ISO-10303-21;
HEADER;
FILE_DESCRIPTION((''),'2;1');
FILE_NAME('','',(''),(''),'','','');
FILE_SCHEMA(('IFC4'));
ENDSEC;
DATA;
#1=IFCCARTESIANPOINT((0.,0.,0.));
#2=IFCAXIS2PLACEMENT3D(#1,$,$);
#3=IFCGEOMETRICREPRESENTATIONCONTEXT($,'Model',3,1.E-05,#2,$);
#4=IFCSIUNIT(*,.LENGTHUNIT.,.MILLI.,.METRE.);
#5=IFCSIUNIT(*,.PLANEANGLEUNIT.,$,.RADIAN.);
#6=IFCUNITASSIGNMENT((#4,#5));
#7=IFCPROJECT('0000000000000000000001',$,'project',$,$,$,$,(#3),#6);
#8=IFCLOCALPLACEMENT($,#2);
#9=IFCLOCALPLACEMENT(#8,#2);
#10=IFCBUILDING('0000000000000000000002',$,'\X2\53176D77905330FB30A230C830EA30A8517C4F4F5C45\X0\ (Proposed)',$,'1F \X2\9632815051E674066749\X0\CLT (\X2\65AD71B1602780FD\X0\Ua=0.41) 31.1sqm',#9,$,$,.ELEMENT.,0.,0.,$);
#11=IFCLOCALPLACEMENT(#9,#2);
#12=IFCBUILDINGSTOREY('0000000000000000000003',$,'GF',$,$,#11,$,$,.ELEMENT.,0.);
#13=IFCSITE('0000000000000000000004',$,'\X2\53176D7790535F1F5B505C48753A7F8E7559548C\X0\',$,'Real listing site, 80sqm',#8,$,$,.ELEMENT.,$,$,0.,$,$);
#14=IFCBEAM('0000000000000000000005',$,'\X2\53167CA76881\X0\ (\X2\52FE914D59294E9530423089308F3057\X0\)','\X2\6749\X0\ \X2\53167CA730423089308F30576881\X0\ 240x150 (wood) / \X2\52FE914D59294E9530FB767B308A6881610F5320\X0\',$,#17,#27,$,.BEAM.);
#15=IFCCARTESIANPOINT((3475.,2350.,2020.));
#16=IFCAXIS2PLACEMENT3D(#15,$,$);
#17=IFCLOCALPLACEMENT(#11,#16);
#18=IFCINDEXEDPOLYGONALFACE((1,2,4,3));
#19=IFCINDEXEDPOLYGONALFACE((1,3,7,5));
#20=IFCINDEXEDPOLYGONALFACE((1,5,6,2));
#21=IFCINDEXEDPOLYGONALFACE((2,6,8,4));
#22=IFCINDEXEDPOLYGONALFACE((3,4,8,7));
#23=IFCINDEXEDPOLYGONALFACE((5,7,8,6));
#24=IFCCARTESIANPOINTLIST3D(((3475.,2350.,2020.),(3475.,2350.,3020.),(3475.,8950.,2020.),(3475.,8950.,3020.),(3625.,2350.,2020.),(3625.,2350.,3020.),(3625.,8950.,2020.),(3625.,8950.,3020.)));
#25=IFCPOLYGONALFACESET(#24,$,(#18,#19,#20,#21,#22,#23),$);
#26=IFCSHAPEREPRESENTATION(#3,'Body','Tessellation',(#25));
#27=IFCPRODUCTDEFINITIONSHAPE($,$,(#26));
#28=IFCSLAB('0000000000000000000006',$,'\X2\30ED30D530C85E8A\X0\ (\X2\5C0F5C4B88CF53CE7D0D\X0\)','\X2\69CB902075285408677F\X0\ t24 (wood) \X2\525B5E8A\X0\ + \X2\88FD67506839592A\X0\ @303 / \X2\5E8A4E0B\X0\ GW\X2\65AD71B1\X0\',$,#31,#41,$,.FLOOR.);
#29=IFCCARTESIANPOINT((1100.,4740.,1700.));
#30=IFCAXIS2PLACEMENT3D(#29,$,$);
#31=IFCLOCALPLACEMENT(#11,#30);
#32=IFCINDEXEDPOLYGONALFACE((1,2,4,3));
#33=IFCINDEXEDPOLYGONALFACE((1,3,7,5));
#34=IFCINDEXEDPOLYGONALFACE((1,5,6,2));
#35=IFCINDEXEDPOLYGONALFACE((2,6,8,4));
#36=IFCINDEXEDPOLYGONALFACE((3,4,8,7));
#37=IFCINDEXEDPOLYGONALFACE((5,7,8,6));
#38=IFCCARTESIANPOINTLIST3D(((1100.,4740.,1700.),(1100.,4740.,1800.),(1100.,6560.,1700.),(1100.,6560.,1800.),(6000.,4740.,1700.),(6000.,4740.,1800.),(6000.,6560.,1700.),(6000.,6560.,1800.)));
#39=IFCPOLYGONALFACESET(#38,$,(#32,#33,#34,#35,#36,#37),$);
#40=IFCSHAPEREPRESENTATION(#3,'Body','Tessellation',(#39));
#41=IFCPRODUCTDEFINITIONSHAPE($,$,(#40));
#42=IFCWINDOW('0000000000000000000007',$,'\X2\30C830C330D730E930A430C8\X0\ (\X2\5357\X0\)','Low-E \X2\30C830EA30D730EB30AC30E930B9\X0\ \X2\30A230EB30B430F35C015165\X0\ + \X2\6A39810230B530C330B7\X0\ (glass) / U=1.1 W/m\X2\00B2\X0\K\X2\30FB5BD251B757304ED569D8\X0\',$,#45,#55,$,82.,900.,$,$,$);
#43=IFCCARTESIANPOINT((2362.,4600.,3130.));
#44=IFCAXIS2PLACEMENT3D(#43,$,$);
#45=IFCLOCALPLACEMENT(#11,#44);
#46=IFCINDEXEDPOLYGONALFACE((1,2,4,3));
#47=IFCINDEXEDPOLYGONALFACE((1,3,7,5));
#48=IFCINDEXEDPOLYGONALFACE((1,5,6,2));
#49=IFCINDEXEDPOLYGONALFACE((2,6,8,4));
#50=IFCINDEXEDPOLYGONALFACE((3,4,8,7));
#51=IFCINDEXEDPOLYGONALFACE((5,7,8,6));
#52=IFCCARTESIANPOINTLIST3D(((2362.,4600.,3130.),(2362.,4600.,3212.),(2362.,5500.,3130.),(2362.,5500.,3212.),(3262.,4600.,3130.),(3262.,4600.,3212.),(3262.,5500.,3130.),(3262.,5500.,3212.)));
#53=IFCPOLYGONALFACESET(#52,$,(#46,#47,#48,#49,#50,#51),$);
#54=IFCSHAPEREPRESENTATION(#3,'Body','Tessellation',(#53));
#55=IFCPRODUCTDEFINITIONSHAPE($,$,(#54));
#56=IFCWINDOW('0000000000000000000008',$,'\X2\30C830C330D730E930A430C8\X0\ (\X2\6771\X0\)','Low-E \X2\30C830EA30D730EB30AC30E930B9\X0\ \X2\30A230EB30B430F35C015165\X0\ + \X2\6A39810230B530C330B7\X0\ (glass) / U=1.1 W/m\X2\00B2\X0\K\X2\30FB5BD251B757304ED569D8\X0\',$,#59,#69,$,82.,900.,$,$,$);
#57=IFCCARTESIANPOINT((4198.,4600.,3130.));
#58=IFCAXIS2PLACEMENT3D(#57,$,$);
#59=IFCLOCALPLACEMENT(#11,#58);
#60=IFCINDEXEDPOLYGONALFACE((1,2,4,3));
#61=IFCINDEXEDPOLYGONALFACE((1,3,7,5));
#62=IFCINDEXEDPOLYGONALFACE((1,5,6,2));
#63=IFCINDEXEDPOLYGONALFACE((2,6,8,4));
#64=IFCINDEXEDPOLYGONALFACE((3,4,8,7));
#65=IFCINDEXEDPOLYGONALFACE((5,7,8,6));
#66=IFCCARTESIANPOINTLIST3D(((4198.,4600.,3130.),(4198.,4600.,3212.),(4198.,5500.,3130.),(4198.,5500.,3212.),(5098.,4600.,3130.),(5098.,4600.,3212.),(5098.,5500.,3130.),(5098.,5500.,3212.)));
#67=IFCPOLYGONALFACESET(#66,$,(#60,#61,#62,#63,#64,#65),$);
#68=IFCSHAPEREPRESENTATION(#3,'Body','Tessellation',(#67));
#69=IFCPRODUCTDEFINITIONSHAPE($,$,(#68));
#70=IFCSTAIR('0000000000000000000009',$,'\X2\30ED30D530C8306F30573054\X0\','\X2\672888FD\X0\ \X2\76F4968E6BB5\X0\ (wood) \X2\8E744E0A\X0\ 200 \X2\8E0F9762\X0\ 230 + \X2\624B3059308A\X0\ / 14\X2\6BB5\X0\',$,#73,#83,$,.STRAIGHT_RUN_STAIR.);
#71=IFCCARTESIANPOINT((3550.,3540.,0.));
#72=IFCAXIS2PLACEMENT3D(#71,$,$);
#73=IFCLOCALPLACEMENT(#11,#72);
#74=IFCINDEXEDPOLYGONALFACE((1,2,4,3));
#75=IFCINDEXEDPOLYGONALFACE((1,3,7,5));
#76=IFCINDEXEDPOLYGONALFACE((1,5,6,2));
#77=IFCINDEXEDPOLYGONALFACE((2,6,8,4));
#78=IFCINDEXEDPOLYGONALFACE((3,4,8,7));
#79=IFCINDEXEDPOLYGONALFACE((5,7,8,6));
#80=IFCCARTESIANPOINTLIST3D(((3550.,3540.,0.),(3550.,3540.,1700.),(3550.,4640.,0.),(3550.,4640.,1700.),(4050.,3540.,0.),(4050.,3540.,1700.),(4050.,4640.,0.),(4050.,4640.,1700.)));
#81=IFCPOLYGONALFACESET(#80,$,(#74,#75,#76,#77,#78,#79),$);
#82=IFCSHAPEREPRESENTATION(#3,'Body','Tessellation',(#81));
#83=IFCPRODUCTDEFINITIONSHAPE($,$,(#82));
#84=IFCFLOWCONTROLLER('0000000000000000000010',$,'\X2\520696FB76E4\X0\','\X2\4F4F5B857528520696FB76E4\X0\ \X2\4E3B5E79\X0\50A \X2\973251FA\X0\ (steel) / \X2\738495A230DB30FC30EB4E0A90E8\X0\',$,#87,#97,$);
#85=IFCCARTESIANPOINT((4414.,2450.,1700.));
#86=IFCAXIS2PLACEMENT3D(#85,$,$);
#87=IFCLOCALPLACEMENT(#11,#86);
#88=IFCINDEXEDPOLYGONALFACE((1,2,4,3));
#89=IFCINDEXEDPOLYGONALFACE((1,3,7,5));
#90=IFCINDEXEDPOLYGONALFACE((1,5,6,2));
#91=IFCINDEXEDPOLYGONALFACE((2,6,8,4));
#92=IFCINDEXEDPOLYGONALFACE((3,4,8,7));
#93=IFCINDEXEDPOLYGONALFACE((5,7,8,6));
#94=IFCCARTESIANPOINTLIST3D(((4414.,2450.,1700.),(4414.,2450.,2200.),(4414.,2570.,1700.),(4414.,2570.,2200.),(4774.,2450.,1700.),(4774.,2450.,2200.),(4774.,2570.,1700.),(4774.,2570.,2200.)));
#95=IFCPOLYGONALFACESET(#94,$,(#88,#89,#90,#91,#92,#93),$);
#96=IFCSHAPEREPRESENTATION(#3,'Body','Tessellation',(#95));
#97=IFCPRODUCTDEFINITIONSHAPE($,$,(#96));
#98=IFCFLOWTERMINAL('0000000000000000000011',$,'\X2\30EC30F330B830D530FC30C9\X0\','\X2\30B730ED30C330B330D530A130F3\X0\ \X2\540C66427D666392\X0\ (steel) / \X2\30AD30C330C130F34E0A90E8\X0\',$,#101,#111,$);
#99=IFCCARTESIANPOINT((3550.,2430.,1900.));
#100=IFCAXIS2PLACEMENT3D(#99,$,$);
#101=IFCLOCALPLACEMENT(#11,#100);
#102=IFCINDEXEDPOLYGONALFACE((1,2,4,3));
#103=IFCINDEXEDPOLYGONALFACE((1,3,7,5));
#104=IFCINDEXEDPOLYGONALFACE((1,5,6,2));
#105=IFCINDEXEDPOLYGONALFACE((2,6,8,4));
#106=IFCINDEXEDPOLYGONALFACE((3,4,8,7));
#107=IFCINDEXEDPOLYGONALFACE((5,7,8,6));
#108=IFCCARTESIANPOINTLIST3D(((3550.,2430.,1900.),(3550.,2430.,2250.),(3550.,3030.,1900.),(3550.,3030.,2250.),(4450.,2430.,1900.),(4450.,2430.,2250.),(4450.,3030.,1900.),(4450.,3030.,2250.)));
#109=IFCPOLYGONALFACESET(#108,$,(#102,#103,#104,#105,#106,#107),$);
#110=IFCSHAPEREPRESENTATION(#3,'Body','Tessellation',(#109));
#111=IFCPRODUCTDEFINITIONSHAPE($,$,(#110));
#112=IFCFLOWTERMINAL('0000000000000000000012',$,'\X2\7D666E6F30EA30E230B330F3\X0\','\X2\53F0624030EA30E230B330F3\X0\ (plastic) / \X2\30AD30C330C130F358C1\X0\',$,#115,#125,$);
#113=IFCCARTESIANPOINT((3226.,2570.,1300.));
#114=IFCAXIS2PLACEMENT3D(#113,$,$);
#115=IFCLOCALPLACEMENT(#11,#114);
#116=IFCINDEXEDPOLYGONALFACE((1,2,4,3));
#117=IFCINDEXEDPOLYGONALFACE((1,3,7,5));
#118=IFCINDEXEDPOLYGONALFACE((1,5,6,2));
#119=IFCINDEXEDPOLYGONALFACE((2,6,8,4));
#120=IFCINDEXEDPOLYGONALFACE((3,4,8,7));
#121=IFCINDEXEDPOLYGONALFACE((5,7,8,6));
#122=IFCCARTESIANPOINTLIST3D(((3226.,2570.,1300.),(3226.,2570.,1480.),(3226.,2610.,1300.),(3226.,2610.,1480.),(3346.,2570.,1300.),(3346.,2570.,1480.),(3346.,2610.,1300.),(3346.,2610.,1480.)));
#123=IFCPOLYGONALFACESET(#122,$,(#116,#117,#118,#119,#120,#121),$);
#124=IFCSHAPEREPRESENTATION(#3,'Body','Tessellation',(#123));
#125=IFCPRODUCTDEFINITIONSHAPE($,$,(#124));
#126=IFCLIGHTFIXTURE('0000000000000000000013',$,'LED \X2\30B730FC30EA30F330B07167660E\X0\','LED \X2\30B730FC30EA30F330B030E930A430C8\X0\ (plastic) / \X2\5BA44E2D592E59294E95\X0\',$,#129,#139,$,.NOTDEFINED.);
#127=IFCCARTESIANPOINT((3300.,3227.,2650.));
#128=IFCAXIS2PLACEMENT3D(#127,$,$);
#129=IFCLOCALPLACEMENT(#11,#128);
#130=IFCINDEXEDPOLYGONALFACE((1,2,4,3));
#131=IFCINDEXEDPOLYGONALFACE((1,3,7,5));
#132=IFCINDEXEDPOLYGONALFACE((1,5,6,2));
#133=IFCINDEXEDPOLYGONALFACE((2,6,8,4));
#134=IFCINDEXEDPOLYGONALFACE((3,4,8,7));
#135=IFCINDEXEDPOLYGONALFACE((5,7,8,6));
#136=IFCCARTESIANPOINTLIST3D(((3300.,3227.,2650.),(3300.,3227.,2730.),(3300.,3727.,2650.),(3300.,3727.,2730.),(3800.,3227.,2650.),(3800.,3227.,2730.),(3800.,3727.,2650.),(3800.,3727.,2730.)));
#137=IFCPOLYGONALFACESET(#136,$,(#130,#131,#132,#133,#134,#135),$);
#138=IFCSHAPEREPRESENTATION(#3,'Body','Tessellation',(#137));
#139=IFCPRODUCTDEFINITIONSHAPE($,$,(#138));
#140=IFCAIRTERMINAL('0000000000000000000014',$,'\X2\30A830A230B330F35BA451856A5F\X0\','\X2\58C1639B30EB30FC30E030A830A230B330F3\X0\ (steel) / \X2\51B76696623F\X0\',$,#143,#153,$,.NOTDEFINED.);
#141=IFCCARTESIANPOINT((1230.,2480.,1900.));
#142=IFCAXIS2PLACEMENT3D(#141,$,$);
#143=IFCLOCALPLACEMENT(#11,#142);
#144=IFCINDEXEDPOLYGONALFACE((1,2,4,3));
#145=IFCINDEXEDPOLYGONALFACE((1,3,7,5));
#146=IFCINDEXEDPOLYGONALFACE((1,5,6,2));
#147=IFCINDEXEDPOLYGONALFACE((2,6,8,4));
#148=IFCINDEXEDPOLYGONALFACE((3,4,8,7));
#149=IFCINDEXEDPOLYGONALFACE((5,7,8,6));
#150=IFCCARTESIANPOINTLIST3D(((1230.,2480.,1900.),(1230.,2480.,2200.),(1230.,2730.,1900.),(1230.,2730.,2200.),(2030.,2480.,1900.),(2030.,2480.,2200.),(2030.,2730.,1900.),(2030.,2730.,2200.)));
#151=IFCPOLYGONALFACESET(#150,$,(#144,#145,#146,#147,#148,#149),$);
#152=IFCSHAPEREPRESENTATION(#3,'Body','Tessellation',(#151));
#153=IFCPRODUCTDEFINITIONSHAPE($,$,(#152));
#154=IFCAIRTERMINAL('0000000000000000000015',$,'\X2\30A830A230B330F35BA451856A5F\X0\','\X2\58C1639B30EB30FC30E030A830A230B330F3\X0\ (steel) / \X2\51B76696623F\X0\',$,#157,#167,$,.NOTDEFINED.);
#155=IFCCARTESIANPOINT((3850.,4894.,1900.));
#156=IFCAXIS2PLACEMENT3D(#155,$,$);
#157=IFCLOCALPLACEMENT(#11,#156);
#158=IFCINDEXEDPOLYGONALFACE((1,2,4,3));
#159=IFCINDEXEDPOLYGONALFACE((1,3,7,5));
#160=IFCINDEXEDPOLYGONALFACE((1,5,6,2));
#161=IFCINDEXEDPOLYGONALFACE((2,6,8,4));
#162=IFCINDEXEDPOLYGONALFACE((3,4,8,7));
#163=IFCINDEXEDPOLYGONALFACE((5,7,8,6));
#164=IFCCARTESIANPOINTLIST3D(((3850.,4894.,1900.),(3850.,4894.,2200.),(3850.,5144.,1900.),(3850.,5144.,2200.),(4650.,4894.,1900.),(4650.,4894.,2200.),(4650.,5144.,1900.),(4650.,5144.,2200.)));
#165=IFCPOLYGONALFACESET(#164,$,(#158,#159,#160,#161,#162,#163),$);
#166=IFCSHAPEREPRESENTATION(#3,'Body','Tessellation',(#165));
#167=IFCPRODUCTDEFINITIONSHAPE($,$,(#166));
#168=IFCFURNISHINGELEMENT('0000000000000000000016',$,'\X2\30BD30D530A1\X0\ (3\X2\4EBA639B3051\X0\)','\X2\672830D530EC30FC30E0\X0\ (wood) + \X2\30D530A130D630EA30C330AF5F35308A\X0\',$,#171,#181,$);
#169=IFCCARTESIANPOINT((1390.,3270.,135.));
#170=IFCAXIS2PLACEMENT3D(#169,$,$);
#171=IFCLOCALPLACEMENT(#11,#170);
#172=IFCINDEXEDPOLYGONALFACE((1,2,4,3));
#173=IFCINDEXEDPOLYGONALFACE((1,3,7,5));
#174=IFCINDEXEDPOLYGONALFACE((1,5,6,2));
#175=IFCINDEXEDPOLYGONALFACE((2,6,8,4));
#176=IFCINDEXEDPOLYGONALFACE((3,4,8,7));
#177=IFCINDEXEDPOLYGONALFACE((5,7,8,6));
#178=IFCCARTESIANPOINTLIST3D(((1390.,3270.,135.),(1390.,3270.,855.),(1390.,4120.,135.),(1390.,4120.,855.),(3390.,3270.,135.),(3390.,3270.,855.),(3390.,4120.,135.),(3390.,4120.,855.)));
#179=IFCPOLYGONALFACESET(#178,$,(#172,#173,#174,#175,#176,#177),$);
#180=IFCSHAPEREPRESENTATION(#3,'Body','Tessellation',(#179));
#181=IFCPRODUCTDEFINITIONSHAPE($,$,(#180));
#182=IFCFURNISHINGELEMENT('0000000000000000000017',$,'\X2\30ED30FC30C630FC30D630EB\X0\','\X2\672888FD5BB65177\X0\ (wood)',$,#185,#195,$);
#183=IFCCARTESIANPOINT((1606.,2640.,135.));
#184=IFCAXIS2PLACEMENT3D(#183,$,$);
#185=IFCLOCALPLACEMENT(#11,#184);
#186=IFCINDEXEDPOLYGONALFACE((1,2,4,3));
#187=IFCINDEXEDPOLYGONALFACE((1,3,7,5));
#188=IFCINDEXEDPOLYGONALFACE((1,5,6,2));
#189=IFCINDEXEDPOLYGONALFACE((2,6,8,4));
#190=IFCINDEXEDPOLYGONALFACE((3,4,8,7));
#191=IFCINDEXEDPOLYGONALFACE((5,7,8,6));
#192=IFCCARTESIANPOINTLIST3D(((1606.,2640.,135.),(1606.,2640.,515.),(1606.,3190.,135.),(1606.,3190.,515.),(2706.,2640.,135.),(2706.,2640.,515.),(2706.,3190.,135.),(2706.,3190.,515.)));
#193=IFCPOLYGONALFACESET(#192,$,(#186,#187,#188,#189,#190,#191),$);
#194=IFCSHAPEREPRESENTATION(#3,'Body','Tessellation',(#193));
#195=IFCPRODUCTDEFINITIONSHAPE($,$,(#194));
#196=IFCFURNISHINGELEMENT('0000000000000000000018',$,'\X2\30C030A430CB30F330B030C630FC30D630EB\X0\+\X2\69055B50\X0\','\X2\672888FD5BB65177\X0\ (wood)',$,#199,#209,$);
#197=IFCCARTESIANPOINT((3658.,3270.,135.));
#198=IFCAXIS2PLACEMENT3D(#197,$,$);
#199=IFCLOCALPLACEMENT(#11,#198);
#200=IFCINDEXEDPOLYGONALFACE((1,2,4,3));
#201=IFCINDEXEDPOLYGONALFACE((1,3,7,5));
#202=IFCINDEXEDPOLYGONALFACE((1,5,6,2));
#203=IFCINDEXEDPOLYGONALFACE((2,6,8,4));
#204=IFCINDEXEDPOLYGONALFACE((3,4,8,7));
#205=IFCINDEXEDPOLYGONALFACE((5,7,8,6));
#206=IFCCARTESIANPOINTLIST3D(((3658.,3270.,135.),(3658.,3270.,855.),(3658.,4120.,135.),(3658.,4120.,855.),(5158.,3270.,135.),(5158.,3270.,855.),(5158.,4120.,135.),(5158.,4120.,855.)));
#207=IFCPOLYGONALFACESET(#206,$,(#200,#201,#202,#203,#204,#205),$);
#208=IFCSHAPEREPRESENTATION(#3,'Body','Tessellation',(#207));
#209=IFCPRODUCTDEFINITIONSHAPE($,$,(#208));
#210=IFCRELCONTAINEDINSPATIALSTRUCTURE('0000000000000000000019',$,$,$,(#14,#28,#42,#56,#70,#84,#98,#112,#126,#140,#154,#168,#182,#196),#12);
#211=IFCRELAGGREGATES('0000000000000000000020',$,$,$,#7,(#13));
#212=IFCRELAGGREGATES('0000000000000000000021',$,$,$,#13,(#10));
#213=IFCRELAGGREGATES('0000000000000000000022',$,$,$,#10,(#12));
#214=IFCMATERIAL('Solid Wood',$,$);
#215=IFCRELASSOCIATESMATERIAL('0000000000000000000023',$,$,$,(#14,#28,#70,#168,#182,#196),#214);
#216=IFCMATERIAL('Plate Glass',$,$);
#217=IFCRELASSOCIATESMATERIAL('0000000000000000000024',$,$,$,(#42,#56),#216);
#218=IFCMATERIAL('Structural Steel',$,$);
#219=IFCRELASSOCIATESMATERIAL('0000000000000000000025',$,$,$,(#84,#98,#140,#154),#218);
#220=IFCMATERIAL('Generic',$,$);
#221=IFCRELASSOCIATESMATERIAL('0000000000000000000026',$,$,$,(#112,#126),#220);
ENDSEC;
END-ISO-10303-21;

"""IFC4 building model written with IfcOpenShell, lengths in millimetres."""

from ifc_helpers import new_model, si_unit, frame, frame_2d, origin, place, context, project, spatial, rectangle, extrude, material, element, save


model = new_model("IFC4")

# Units and contexts
model_context = context("Model", 3, precision=1e-05, world=origin())
ifc_project = project(units=[si_unit("LENGTHUNIT", "METRE", prefix="MILLI"), si_unit("PLANEANGLEUNIT", "RADIAN")], contexts=[model_context])

# Site, building, storey
site_placement = place(None, origin())
site = spatial("IfcSite", under=ifc_project, at=site_placement, Name="北海道弟子屈町美留和", ObjectType="Real listing site, 80sqm", CompositionType="ELEMENT", RefElevation=0.0)
building_placement = place(site_placement, origin())
building = spatial("IfcBuilding", under=site, at=building_placement, Name="北海道・アトリエ兼住居 (Proposed)", ObjectType="1F 防腐処理杉CLT (断熱性能Ua=0.41) 31.1sqm", CompositionType="ELEMENT", ElevationOfRefHeight=0.0, ElevationOfTerrain=0.0)
storey_placement = place(building_placement, origin())
storey = spatial("IfcBuildingStorey", under=building, at=storey_placement, Name="GF", CompositionType="ELEMENT", Elevation=0.0)

# Shared definitions
ifc_material_1 = material(Name="Solid Wood")

# Beam
beam_placement = place(storey_placement, frame((3475.0, 2350.0, 2020.0)))
element("IfcBeam", 1, at=beam_placement, inside=storey, material=ifc_material_1, Name="化粧梁 (勾配天井あらわし)", Description="杉 化粧あらわし梁 240x150 (wood) / 勾配天井・登り梁意匠", PredefinedType="BEAM", context=model_context, shape_type="SweptSolid", body=[
    extrude(rectangle(XDim=150.0, YDim=6600.0, at=frame_2d((75.0, 3300.0))), frame((3475.0, 2350.0, 2020.0)), (0.0, 0.0, 1.0), 1000.0),
])

# Slab
slab_placement = place(storey_placement, frame((1100.0, 4740.0, 1700.0)))
element("IfcSlab", 2, at=slab_placement, inside=storey, material=ifc_material_1, Name="ロフト床 (小屋裏収納)", Description="構造用合板 t24 (wood) 剛床 + 製材根太 @303 / 床下 GW断熱", PredefinedType="FLOOR", context=model_context, shape_type="SweptSolid", body=[
    extrude(rectangle(XDim=4900.0, YDim=1820.0, at=frame_2d((2450.0, 910.0))), frame((1100.0, 4740.0, 1700.0)), (0.0, 0.0, 1.0), 100.0),
])

# Windows
ifc_material_2 = material(Name="Plate Glass")
window_1_placement = place(storey_placement, frame((2362.0, 4600.0, 3130.0)))
element("IfcWindow", 3, at=window_1_placement, inside=storey, material=ifc_material_2, Name="トップライト (南)", Description="Low-E トリプルガラス アルゴン封入 + 樹脂サッシ (glass) / U=1.1 W/m²K・寒冷地仕様", OverallHeight=82.0, OverallWidth=900.0, context=model_context, shape_type="SweptSolid", body=[
    extrude(rectangle(XDim=900.0, YDim=900.0, at=frame_2d((450.0, 450.0))), frame((2362.0, 4600.0, 3130.0)), (0.0, 0.0, 1.0), 82.0),
])
window_2_placement = place(storey_placement, frame((4198.0, 4600.0, 3130.0)))
element("IfcWindow", 4, at=window_2_placement, inside=storey, material=ifc_material_2, Name="トップライト (東)", Description="Low-E トリプルガラス アルゴン封入 + 樹脂サッシ (glass) / U=1.1 W/m²K・寒冷地仕様", OverallHeight=82.0, OverallWidth=900.0, context=model_context, shape_type="SweptSolid", body=[
    extrude(rectangle(XDim=900.0, YDim=900.0, at=frame_2d((450.0, 450.0))), frame((4198.0, 4600.0, 3130.0)), (0.0, 0.0, 1.0), 82.0),
])

# Stair
stair_placement = place(storey_placement, frame((3550.0, 3540.0, 0.0)))
element("IfcStair", 5, at=stair_placement, inside=storey, material=ifc_material_1, Name="ロフトはしご", Description="木製 直階段 (wood) 蹴上 200 踏面 230 + 手すり / 14段", PredefinedType="STRAIGHT_RUN_STAIR", context=model_context, shape_type="SweptSolid", body=[
    extrude(rectangle(XDim=500.0, YDim=1100.0, at=frame_2d((250.0, 550.0))), frame((3550.0, 3540.0, 0.0)), (0.0, 0.0, 1.0), 1700.0),
])

# Flow controller
ifc_material_3 = material(Name="Structural Steel")
flow_controller_placement = place(storey_placement, frame((4414.0, 2450.0, 1700.0)))
element("IfcFlowController", 6, at=flow_controller_placement, inside=storey, material=ifc_material_3, Name="分電盤", Description="住宅用分電盤 主幹50A 露出 (steel) / 玄関ホール上部", context=model_context, shape_type="SweptSolid", body=[
    extrude(rectangle(XDim=360.0, YDim=120.0, at=frame_2d((180.0, 60.0))), frame((4414.0, 2450.0, 1700.0)), (0.0, 0.0, 1.0), 500.0),
])

# Flow terminals
flow_terminal_1_placement = place(storey_placement, frame((3550.0, 2430.0, 1900.0)))
element("IfcFlowTerminal", 7, at=flow_terminal_1_placement, inside=storey, material=ifc_material_3, Name="レンジフード", Description="シロッコファン 同時給排 (steel) / キッチン上部", context=model_context, shape_type="SweptSolid", body=[
    extrude(rectangle(XDim=900.0, YDim=600.0, at=frame_2d((450.0, 300.0))), frame((3550.0, 2430.0, 1900.0)), (0.0, 0.0, 1.0), 350.0),
])
ifc_material_4 = material(Name="Generic")
flow_terminal_2_placement = place(storey_placement, frame((3226.0, 2570.0, 1300.0)))
element("IfcFlowTerminal", 8, at=flow_terminal_2_placement, inside=storey, material=ifc_material_4, Name="給湯リモコン", Description="台所リモコン (plastic) / キッチン壁", context=model_context, shape_type="SweptSolid", body=[
    extrude(rectangle(XDim=120.0, YDim=40.0, at=frame_2d((60.0, 20.0))), frame((3226.0, 2570.0, 1300.0)), (0.0, 0.0, 1.0), 180.0),
])

# Light fixture
light_fixture_placement = place(storey_placement, frame((3300.0, 3227.0, 2650.0)))
element("IfcLightFixture", 9, at=light_fixture_placement, inside=storey, material=ifc_material_4, Name="LED シーリング照明", Description="LED シーリングライト (plastic) / 室中央天井", PredefinedType="NOTDEFINED", context=model_context, shape_type="SweptSolid", body=[
    extrude(rectangle(XDim=500.0, YDim=500.0, at=frame_2d((250.0, 250.0))), frame((3300.0, 3227.0, 2650.0)), (0.0, 0.0, 1.0), 80.0),
])

# Air terminals
air_terminal_1_placement = place(storey_placement, frame((1230.0, 2480.0, 1900.0)))
element("IfcAirTerminal", 10, at=air_terminal_1_placement, inside=storey, material=ifc_material_3, Name="エアコン室内機", Description="壁掛ルームエアコン (steel) / 冷暖房", PredefinedType="NOTDEFINED", context=model_context, shape_type="SweptSolid", body=[
    extrude(rectangle(XDim=800.0, YDim=250.0, at=frame_2d((400.0, 125.0))), frame((1230.0, 2480.0, 1900.0)), (0.0, 0.0, 1.0), 300.0),
])
air_terminal_2_placement = place(storey_placement, frame((3850.0, 4894.0, 1900.0)))
element("IfcAirTerminal", 11, at=air_terminal_2_placement, inside=storey, material=ifc_material_3, Name="エアコン室内機", Description="壁掛ルームエアコン (steel) / 冷暖房", PredefinedType="NOTDEFINED", context=model_context, shape_type="SweptSolid", body=[
    extrude(rectangle(XDim=800.0, YDim=250.0, at=frame_2d((400.0, 125.0))), frame((3850.0, 4894.0, 1900.0)), (0.0, 0.0, 1.0), 300.0),
])

# Furnishing elements
furnishing_1_placement = place(storey_placement, frame((1390.0, 3270.0, 135.0)))
element("IfcFurnishingElement", 12, at=furnishing_1_placement, inside=storey, material=ifc_material_1, Name="ソファ (3人掛け)", Description="木フレーム (wood) + ファブリック張り", context=model_context, shape_type="SweptSolid", body=[
    extrude(rectangle(XDim=2000.0, YDim=850.0, at=frame_2d((1000.0, 425.0))), frame((1390.0, 3270.0, 135.0)), (0.0, 0.0, 1.0), 720.0),
])
furnishing_2_placement = place(storey_placement, frame((1606.0, 2640.0, 135.0)))
element("IfcFurnishingElement", 13, at=furnishing_2_placement, inside=storey, material=ifc_material_1, Name="ローテーブル", Description="木製家具 (wood)", context=model_context, shape_type="SweptSolid", body=[
    extrude(rectangle(XDim=1100.0, YDim=550.0, at=frame_2d((550.0, 275.0))), frame((1606.0, 2640.0, 135.0)), (0.0, 0.0, 1.0), 380.0),
])
furnishing_3_placement = place(storey_placement, frame((3658.0, 3270.0, 135.0)))
element("IfcFurnishingElement", 14, at=furnishing_3_placement, inside=storey, material=ifc_material_1, Name="ダイニングテーブル+椅子", Description="木製家具 (wood)", context=model_context, shape_type="SweptSolid", body=[
    extrude(rectangle(XDim=1500.0, YDim=850.0, at=frame_2d((750.0, 425.0))), frame((3658.0, 3270.0, 135.0)), (0.0, 0.0, 1.0), 720.0),
])

save(model, "model.ifc")
